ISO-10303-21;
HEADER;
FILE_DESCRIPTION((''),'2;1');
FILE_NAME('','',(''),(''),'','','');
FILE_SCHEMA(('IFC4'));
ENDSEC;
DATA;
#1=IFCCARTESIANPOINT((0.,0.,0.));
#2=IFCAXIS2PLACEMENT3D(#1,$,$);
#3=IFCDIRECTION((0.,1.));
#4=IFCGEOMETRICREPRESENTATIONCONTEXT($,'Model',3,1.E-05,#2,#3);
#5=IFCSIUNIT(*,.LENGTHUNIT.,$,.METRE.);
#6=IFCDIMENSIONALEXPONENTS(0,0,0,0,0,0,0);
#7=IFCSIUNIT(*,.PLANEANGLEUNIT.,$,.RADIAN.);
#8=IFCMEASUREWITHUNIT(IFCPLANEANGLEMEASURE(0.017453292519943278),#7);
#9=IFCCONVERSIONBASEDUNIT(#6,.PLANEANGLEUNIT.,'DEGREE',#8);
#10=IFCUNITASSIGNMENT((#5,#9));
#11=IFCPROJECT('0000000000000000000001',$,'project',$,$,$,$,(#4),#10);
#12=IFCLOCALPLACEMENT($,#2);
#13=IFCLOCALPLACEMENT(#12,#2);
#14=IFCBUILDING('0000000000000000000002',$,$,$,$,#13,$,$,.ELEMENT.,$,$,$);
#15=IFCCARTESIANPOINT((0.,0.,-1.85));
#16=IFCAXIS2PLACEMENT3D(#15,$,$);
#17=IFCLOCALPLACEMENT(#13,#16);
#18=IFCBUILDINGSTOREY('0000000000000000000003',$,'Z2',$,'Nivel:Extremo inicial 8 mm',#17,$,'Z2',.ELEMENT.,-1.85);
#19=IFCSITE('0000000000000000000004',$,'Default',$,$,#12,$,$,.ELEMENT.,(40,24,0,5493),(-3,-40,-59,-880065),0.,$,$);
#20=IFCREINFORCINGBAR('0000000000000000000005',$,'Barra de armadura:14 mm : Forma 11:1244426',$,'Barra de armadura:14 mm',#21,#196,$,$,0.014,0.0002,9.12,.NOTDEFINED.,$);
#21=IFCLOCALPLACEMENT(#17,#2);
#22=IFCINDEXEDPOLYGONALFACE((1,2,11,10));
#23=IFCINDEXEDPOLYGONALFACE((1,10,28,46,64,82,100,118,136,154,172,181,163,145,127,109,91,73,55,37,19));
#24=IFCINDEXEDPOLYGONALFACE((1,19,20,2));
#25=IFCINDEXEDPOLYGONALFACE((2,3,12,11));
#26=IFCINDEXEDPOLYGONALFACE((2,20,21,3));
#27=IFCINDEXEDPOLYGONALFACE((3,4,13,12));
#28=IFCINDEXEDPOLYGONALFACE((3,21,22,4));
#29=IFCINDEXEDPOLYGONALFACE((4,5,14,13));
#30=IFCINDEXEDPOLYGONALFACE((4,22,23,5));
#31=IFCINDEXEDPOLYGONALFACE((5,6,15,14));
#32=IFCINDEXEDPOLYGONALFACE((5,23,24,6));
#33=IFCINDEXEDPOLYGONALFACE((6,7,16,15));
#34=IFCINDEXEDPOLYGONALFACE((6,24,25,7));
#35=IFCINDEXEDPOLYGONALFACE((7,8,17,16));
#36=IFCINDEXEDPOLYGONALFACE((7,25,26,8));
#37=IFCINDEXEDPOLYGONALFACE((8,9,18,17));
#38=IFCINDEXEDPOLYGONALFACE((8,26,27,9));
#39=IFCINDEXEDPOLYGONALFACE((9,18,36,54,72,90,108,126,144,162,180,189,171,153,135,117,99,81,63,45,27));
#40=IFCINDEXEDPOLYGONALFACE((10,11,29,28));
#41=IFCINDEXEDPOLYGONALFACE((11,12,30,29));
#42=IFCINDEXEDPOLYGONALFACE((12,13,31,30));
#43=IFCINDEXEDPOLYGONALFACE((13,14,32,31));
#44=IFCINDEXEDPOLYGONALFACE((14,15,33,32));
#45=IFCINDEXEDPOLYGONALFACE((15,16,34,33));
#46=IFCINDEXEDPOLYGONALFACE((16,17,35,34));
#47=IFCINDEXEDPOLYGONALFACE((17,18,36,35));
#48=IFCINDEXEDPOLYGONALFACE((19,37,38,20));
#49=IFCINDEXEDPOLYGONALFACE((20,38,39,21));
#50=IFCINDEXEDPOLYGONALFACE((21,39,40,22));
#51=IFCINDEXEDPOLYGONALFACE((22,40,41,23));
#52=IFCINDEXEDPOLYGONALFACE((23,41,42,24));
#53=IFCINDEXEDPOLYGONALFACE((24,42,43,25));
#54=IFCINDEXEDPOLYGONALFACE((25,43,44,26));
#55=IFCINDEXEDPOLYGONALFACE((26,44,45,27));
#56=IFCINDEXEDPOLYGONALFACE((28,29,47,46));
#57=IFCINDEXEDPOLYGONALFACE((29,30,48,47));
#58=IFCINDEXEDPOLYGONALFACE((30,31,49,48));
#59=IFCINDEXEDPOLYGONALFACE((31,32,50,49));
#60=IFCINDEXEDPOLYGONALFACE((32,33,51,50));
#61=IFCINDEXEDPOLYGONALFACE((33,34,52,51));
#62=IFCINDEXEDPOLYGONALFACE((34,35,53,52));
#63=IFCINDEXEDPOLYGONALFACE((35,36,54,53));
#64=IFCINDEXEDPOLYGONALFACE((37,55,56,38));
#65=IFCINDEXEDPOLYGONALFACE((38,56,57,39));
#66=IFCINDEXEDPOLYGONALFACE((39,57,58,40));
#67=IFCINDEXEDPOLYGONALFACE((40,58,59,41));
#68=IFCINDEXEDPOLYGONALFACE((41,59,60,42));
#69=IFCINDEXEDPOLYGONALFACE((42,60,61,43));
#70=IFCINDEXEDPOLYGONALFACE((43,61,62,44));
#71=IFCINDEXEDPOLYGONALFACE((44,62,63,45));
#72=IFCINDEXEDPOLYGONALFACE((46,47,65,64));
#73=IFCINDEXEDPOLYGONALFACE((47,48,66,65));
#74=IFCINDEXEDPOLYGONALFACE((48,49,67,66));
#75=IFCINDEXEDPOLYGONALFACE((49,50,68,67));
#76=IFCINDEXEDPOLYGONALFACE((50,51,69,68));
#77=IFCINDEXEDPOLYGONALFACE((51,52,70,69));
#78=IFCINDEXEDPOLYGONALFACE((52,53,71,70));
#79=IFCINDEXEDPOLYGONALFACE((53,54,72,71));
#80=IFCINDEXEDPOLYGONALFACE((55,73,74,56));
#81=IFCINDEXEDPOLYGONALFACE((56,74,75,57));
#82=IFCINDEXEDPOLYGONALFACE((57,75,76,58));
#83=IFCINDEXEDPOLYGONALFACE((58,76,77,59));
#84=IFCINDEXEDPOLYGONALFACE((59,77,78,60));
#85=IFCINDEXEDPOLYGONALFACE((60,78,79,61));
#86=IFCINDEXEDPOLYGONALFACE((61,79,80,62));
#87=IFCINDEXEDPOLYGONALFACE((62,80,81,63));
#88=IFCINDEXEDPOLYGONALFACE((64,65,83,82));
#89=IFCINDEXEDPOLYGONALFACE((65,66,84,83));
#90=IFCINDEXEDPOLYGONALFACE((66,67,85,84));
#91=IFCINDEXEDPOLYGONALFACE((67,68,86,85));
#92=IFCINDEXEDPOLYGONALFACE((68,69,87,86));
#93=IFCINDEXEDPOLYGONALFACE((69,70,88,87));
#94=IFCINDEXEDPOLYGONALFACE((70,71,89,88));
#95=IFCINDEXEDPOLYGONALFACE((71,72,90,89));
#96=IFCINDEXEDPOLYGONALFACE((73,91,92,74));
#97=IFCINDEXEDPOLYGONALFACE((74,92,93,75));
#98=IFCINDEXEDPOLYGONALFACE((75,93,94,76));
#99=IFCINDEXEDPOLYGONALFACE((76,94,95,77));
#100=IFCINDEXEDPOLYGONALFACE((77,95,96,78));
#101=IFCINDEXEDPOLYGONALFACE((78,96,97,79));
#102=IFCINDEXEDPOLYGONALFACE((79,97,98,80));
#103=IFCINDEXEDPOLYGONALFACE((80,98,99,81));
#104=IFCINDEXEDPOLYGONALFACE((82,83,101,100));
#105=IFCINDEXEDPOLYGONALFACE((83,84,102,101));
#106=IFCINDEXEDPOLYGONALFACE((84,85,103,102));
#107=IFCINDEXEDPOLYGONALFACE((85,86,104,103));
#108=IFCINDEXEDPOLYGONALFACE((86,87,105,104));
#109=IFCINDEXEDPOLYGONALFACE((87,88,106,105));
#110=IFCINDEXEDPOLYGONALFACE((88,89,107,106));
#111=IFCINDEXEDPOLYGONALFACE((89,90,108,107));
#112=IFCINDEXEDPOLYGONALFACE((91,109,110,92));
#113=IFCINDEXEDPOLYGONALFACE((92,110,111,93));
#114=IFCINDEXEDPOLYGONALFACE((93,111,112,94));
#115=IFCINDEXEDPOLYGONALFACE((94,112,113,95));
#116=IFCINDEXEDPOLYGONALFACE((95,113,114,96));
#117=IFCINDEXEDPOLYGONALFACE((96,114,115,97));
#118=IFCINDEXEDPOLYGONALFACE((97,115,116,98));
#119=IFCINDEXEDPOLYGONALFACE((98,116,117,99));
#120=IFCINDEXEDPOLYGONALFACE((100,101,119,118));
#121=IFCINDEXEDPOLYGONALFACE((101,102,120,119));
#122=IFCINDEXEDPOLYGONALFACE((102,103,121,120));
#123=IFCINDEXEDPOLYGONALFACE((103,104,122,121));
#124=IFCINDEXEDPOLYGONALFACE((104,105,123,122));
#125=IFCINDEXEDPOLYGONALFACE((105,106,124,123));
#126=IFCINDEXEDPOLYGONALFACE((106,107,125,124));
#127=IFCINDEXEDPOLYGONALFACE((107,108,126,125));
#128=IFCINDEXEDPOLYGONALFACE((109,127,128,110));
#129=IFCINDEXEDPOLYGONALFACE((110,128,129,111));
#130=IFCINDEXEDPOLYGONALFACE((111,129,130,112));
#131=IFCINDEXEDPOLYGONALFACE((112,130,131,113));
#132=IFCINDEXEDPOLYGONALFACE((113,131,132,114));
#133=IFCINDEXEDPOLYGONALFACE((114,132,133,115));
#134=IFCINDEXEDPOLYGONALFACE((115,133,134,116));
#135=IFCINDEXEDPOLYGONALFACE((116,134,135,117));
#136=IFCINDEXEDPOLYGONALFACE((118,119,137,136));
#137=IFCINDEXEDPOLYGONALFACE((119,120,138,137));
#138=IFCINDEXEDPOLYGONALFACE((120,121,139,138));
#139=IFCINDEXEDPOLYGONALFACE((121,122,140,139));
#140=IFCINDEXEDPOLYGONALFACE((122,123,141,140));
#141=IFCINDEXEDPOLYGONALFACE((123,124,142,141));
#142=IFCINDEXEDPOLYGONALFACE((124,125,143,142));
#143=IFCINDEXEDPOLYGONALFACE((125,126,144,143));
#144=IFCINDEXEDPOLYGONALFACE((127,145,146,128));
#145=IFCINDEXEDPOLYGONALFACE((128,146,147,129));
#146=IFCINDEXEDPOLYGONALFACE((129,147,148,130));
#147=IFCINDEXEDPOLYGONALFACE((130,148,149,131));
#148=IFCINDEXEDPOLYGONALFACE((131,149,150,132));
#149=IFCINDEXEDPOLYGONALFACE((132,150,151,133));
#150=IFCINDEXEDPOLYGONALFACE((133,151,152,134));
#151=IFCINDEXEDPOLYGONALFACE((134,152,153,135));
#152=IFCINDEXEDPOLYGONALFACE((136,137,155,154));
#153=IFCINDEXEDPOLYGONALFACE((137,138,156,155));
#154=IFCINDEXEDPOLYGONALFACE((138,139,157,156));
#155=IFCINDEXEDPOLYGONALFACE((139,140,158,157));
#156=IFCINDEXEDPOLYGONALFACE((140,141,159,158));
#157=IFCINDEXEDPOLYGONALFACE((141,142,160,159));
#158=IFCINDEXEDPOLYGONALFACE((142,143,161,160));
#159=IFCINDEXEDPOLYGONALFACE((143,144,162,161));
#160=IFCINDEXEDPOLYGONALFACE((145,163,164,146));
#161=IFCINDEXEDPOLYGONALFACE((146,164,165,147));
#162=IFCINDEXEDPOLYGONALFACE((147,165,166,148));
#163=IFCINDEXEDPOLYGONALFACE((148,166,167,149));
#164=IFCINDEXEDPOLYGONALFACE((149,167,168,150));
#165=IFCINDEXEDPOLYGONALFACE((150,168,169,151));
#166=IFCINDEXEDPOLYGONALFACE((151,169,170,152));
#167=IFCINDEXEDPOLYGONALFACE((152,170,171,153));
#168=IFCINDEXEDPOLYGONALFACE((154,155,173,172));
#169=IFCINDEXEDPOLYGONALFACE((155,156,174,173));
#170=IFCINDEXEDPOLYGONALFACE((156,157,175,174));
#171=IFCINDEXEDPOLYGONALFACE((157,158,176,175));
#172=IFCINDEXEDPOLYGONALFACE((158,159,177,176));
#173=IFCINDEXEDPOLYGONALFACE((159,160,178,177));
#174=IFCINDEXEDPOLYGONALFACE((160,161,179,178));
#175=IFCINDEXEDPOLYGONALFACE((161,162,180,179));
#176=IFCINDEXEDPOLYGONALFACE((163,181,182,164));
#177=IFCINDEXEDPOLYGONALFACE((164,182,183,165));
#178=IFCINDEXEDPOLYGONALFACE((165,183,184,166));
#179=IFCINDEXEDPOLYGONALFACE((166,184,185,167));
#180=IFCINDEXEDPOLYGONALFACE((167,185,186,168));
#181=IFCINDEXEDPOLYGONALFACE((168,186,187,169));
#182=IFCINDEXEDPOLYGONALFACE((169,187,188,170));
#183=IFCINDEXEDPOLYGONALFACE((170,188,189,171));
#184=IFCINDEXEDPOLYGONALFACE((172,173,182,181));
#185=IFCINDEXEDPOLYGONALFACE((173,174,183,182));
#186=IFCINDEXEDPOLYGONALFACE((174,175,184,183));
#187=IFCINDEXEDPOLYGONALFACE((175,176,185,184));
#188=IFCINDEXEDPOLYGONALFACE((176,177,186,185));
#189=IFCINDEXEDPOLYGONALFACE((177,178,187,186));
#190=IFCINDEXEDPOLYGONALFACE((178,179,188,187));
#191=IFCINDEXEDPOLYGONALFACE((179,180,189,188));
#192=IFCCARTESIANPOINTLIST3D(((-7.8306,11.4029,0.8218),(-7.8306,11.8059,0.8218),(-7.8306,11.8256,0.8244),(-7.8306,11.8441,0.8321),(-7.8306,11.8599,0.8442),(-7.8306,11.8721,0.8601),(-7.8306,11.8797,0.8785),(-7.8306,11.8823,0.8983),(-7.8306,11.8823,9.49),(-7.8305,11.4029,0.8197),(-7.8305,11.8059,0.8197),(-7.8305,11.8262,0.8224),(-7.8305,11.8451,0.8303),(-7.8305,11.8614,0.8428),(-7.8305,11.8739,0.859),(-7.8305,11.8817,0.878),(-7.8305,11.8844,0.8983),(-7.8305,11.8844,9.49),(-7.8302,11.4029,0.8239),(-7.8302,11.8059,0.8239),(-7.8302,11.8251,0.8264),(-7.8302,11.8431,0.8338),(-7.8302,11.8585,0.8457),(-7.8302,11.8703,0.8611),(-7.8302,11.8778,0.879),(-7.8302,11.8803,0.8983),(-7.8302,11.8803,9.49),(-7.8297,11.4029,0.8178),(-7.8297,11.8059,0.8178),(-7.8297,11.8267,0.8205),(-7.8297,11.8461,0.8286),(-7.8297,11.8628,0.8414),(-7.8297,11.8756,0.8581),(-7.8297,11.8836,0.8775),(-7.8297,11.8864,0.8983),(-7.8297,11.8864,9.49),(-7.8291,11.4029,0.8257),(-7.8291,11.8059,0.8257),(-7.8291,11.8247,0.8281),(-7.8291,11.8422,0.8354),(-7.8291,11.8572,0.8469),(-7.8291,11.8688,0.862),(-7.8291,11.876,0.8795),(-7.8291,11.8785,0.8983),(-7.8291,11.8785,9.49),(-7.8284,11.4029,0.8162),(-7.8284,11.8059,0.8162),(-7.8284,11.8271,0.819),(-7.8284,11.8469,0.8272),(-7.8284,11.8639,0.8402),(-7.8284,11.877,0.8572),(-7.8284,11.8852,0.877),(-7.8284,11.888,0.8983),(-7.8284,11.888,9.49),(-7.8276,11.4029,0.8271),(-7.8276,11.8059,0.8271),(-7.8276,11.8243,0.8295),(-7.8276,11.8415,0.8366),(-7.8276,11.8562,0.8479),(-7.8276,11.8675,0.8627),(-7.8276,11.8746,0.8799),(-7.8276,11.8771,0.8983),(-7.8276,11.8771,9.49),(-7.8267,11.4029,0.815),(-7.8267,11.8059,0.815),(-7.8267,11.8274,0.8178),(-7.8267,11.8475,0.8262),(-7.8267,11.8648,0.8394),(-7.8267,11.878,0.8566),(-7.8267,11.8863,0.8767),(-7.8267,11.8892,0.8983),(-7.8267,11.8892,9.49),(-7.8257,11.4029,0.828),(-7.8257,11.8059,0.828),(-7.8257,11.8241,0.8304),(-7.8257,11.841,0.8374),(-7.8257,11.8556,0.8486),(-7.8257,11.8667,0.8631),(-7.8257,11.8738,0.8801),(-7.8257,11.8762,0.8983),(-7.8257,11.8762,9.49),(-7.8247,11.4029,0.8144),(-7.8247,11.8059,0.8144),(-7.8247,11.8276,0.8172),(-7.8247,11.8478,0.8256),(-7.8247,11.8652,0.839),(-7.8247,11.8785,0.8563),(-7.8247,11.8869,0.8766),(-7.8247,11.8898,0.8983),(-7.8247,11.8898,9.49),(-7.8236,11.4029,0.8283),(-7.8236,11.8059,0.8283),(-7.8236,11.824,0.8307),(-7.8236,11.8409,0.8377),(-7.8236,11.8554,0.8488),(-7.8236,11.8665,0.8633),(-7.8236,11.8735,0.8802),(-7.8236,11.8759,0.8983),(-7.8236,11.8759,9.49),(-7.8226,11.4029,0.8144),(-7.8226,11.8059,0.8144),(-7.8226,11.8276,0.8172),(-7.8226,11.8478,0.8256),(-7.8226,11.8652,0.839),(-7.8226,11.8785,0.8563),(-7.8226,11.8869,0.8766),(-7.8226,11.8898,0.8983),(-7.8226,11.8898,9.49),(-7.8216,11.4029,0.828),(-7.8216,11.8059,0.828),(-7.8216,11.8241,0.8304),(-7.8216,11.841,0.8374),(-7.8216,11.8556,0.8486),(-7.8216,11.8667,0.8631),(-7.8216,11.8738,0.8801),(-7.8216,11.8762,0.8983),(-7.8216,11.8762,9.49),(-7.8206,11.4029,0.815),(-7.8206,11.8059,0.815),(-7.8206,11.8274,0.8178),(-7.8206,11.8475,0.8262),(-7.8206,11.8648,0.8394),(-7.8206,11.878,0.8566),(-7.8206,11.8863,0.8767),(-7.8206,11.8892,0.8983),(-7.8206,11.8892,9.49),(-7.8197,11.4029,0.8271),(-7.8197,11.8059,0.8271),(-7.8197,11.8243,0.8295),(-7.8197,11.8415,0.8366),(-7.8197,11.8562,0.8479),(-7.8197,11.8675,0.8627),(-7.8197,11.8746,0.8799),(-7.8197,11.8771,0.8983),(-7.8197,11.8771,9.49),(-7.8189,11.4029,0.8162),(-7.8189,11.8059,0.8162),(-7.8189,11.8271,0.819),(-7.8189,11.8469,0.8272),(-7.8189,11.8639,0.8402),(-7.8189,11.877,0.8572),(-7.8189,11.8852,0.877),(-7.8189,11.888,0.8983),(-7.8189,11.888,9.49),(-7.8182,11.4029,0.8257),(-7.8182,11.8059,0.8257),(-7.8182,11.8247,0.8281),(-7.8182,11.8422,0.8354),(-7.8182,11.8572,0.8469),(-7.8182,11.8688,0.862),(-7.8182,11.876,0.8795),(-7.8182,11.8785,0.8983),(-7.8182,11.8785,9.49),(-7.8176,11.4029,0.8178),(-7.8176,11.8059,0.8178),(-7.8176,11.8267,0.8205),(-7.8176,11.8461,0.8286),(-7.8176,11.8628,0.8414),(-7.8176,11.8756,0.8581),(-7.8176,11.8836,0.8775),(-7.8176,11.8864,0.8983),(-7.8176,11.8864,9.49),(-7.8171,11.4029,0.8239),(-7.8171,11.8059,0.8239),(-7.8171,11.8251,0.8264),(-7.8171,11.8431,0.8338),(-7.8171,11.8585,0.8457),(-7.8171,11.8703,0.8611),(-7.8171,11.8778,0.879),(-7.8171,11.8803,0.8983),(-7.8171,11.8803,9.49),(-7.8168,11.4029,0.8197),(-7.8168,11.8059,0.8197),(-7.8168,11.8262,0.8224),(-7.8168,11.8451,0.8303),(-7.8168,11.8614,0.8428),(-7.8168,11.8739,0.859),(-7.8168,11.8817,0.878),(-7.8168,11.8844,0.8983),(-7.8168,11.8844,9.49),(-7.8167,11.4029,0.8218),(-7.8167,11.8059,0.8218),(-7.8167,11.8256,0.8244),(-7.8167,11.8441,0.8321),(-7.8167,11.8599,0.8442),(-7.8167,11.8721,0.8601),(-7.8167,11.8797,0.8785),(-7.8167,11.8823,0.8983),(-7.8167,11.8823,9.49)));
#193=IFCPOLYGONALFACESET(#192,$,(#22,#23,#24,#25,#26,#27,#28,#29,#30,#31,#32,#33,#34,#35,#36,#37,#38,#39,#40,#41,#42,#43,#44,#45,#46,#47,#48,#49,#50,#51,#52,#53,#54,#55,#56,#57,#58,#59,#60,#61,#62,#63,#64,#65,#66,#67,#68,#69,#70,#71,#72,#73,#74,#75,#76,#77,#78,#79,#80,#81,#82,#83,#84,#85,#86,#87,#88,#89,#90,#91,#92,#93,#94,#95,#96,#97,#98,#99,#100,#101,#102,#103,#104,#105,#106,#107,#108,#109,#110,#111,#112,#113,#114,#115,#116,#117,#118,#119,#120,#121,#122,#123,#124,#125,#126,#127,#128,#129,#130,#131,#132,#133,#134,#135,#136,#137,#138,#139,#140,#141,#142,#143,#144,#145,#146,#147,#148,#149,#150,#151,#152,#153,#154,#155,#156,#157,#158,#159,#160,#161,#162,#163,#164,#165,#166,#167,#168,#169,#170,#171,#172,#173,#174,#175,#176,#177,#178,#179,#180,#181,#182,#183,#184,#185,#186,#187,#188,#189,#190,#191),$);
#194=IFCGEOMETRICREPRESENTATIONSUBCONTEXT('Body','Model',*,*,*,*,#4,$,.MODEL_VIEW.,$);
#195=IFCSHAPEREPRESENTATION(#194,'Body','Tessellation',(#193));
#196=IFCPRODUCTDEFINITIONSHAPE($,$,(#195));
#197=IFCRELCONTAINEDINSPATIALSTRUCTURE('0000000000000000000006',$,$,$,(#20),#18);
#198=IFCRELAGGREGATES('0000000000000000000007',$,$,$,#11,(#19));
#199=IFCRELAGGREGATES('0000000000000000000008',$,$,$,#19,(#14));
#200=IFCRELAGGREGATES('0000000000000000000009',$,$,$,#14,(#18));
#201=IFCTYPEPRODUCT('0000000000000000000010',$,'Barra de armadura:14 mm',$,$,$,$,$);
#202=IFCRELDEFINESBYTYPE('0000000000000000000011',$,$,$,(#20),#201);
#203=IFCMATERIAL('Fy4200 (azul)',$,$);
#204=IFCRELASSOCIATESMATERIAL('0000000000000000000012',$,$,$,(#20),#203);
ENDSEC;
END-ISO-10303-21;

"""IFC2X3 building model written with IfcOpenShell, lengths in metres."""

from ifc_helpers import new_model, entity, si_unit, converted_unit, direction, frame, origin, place, context, subcontext, project, spatial, material, type_object, element, save


model = new_model("IFC2X3")

# Units and contexts
model_context = context("Model", 3, precision=1e-05, world=origin(), true_north=direction((0.0, 1.0)))
body_context = subcontext(model_context, "Body", "Model", "MODEL_VIEW")
ifc_project = project(units=[si_unit("LENGTHUNIT", "METRE"), converted_unit("PLANEANGLEUNIT", "DEGREE", entity("IfcPlaneAngleMeasure", 0.017453292519943278), si_unit("PLANEANGLEUNIT", "RADIAN"), dimensions=[0, 0, 0, 0, 0, 0, 0])], contexts=[model_context])

# Site, building, storey
site_placement = place(None, origin())
site = spatial("IfcSite", under=ifc_project, at=site_placement, Name="Default", CompositionType="ELEMENT", RefLatitude=(40, 24, 0, 5493), RefLongitude=(-3, -40, -59, -880065), RefElevation=0.0)
building_placement = place(site_placement, origin())
building = spatial("IfcBuilding", under=site, at=building_placement, CompositionType="ELEMENT")
storey_placement = place(building_placement, frame((0.0, 0.0, -1.85)))
storey = spatial("IfcBuildingStorey", under=building, at=storey_placement, Name="Z2", ObjectType="Nivel:Extremo inicial 8 mm", LongName="Z2", CompositionType="ELEMENT", Elevation=-1.85)

# Reinforcing bar
ifc_material_1 = material(Name="Fy4200 (azul)")
type_product_1 = type_object("IfcTypeProduct", Name="Barra de armadura:14 mm")
reinforcing_bar_1_placement = place(storey_placement, origin())
element("IfcReinforcingBar", 1, at=reinforcing_bar_1_placement, inside=storey, type_object=type_product_1, material=ifc_material_1, Name="Barra de armadura:14 mm : Forma 11:1244426", ObjectType="Barra de armadura:14 mm", BarLength=9.12, BarRole="NOTDEFINED", CrossSectionArea=0.0002, NominalDiameter=0.014, context=body_context, shape_type="AdvancedSweptSolid", body=[
    entity("IfcSweptDiskSolid", entity("IfcCompositeCurve", [entity("IfcCompositeCurveSegment", "CONTINUOUS", True, entity("IfcPolyline", [entity("IfcCartesianPoint", [-7.8236, 11.8829, 9.49]), entity("IfcCartesianPoint", [-7.8236, 11.8829, 0.8983])])), entity("IfcCompositeCurveSegment", "CONTINUOUS", True, entity("IfcTrimmedCurve", entity("IfcCircle", entity("IfcAxis2Placement3D", entity("IfcCartesianPoint", [-7.8236, 11.8059, 0.8983]), entity("IfcDirection", [-1.0, 0.0, 0.0]), entity("IfcDirection", [0.0, 0.0, -1.0])), 0.077), [entity("IfcParameterValue", 270.0)], [entity("IfcParameterValue", 360.0)], True, "PARAMETER")), entity("IfcCompositeCurveSegment", "CONTINUOUS", True, entity("IfcPolyline", [entity("IfcCartesianPoint", [-7.8236, 11.8059, 0.8213]), entity("IfcCartesianPoint", [-7.8236, 11.4029, 0.8213])]))], False), 0.007, None, 0.0, 92.0),
])

save(model, "model.ifc")
